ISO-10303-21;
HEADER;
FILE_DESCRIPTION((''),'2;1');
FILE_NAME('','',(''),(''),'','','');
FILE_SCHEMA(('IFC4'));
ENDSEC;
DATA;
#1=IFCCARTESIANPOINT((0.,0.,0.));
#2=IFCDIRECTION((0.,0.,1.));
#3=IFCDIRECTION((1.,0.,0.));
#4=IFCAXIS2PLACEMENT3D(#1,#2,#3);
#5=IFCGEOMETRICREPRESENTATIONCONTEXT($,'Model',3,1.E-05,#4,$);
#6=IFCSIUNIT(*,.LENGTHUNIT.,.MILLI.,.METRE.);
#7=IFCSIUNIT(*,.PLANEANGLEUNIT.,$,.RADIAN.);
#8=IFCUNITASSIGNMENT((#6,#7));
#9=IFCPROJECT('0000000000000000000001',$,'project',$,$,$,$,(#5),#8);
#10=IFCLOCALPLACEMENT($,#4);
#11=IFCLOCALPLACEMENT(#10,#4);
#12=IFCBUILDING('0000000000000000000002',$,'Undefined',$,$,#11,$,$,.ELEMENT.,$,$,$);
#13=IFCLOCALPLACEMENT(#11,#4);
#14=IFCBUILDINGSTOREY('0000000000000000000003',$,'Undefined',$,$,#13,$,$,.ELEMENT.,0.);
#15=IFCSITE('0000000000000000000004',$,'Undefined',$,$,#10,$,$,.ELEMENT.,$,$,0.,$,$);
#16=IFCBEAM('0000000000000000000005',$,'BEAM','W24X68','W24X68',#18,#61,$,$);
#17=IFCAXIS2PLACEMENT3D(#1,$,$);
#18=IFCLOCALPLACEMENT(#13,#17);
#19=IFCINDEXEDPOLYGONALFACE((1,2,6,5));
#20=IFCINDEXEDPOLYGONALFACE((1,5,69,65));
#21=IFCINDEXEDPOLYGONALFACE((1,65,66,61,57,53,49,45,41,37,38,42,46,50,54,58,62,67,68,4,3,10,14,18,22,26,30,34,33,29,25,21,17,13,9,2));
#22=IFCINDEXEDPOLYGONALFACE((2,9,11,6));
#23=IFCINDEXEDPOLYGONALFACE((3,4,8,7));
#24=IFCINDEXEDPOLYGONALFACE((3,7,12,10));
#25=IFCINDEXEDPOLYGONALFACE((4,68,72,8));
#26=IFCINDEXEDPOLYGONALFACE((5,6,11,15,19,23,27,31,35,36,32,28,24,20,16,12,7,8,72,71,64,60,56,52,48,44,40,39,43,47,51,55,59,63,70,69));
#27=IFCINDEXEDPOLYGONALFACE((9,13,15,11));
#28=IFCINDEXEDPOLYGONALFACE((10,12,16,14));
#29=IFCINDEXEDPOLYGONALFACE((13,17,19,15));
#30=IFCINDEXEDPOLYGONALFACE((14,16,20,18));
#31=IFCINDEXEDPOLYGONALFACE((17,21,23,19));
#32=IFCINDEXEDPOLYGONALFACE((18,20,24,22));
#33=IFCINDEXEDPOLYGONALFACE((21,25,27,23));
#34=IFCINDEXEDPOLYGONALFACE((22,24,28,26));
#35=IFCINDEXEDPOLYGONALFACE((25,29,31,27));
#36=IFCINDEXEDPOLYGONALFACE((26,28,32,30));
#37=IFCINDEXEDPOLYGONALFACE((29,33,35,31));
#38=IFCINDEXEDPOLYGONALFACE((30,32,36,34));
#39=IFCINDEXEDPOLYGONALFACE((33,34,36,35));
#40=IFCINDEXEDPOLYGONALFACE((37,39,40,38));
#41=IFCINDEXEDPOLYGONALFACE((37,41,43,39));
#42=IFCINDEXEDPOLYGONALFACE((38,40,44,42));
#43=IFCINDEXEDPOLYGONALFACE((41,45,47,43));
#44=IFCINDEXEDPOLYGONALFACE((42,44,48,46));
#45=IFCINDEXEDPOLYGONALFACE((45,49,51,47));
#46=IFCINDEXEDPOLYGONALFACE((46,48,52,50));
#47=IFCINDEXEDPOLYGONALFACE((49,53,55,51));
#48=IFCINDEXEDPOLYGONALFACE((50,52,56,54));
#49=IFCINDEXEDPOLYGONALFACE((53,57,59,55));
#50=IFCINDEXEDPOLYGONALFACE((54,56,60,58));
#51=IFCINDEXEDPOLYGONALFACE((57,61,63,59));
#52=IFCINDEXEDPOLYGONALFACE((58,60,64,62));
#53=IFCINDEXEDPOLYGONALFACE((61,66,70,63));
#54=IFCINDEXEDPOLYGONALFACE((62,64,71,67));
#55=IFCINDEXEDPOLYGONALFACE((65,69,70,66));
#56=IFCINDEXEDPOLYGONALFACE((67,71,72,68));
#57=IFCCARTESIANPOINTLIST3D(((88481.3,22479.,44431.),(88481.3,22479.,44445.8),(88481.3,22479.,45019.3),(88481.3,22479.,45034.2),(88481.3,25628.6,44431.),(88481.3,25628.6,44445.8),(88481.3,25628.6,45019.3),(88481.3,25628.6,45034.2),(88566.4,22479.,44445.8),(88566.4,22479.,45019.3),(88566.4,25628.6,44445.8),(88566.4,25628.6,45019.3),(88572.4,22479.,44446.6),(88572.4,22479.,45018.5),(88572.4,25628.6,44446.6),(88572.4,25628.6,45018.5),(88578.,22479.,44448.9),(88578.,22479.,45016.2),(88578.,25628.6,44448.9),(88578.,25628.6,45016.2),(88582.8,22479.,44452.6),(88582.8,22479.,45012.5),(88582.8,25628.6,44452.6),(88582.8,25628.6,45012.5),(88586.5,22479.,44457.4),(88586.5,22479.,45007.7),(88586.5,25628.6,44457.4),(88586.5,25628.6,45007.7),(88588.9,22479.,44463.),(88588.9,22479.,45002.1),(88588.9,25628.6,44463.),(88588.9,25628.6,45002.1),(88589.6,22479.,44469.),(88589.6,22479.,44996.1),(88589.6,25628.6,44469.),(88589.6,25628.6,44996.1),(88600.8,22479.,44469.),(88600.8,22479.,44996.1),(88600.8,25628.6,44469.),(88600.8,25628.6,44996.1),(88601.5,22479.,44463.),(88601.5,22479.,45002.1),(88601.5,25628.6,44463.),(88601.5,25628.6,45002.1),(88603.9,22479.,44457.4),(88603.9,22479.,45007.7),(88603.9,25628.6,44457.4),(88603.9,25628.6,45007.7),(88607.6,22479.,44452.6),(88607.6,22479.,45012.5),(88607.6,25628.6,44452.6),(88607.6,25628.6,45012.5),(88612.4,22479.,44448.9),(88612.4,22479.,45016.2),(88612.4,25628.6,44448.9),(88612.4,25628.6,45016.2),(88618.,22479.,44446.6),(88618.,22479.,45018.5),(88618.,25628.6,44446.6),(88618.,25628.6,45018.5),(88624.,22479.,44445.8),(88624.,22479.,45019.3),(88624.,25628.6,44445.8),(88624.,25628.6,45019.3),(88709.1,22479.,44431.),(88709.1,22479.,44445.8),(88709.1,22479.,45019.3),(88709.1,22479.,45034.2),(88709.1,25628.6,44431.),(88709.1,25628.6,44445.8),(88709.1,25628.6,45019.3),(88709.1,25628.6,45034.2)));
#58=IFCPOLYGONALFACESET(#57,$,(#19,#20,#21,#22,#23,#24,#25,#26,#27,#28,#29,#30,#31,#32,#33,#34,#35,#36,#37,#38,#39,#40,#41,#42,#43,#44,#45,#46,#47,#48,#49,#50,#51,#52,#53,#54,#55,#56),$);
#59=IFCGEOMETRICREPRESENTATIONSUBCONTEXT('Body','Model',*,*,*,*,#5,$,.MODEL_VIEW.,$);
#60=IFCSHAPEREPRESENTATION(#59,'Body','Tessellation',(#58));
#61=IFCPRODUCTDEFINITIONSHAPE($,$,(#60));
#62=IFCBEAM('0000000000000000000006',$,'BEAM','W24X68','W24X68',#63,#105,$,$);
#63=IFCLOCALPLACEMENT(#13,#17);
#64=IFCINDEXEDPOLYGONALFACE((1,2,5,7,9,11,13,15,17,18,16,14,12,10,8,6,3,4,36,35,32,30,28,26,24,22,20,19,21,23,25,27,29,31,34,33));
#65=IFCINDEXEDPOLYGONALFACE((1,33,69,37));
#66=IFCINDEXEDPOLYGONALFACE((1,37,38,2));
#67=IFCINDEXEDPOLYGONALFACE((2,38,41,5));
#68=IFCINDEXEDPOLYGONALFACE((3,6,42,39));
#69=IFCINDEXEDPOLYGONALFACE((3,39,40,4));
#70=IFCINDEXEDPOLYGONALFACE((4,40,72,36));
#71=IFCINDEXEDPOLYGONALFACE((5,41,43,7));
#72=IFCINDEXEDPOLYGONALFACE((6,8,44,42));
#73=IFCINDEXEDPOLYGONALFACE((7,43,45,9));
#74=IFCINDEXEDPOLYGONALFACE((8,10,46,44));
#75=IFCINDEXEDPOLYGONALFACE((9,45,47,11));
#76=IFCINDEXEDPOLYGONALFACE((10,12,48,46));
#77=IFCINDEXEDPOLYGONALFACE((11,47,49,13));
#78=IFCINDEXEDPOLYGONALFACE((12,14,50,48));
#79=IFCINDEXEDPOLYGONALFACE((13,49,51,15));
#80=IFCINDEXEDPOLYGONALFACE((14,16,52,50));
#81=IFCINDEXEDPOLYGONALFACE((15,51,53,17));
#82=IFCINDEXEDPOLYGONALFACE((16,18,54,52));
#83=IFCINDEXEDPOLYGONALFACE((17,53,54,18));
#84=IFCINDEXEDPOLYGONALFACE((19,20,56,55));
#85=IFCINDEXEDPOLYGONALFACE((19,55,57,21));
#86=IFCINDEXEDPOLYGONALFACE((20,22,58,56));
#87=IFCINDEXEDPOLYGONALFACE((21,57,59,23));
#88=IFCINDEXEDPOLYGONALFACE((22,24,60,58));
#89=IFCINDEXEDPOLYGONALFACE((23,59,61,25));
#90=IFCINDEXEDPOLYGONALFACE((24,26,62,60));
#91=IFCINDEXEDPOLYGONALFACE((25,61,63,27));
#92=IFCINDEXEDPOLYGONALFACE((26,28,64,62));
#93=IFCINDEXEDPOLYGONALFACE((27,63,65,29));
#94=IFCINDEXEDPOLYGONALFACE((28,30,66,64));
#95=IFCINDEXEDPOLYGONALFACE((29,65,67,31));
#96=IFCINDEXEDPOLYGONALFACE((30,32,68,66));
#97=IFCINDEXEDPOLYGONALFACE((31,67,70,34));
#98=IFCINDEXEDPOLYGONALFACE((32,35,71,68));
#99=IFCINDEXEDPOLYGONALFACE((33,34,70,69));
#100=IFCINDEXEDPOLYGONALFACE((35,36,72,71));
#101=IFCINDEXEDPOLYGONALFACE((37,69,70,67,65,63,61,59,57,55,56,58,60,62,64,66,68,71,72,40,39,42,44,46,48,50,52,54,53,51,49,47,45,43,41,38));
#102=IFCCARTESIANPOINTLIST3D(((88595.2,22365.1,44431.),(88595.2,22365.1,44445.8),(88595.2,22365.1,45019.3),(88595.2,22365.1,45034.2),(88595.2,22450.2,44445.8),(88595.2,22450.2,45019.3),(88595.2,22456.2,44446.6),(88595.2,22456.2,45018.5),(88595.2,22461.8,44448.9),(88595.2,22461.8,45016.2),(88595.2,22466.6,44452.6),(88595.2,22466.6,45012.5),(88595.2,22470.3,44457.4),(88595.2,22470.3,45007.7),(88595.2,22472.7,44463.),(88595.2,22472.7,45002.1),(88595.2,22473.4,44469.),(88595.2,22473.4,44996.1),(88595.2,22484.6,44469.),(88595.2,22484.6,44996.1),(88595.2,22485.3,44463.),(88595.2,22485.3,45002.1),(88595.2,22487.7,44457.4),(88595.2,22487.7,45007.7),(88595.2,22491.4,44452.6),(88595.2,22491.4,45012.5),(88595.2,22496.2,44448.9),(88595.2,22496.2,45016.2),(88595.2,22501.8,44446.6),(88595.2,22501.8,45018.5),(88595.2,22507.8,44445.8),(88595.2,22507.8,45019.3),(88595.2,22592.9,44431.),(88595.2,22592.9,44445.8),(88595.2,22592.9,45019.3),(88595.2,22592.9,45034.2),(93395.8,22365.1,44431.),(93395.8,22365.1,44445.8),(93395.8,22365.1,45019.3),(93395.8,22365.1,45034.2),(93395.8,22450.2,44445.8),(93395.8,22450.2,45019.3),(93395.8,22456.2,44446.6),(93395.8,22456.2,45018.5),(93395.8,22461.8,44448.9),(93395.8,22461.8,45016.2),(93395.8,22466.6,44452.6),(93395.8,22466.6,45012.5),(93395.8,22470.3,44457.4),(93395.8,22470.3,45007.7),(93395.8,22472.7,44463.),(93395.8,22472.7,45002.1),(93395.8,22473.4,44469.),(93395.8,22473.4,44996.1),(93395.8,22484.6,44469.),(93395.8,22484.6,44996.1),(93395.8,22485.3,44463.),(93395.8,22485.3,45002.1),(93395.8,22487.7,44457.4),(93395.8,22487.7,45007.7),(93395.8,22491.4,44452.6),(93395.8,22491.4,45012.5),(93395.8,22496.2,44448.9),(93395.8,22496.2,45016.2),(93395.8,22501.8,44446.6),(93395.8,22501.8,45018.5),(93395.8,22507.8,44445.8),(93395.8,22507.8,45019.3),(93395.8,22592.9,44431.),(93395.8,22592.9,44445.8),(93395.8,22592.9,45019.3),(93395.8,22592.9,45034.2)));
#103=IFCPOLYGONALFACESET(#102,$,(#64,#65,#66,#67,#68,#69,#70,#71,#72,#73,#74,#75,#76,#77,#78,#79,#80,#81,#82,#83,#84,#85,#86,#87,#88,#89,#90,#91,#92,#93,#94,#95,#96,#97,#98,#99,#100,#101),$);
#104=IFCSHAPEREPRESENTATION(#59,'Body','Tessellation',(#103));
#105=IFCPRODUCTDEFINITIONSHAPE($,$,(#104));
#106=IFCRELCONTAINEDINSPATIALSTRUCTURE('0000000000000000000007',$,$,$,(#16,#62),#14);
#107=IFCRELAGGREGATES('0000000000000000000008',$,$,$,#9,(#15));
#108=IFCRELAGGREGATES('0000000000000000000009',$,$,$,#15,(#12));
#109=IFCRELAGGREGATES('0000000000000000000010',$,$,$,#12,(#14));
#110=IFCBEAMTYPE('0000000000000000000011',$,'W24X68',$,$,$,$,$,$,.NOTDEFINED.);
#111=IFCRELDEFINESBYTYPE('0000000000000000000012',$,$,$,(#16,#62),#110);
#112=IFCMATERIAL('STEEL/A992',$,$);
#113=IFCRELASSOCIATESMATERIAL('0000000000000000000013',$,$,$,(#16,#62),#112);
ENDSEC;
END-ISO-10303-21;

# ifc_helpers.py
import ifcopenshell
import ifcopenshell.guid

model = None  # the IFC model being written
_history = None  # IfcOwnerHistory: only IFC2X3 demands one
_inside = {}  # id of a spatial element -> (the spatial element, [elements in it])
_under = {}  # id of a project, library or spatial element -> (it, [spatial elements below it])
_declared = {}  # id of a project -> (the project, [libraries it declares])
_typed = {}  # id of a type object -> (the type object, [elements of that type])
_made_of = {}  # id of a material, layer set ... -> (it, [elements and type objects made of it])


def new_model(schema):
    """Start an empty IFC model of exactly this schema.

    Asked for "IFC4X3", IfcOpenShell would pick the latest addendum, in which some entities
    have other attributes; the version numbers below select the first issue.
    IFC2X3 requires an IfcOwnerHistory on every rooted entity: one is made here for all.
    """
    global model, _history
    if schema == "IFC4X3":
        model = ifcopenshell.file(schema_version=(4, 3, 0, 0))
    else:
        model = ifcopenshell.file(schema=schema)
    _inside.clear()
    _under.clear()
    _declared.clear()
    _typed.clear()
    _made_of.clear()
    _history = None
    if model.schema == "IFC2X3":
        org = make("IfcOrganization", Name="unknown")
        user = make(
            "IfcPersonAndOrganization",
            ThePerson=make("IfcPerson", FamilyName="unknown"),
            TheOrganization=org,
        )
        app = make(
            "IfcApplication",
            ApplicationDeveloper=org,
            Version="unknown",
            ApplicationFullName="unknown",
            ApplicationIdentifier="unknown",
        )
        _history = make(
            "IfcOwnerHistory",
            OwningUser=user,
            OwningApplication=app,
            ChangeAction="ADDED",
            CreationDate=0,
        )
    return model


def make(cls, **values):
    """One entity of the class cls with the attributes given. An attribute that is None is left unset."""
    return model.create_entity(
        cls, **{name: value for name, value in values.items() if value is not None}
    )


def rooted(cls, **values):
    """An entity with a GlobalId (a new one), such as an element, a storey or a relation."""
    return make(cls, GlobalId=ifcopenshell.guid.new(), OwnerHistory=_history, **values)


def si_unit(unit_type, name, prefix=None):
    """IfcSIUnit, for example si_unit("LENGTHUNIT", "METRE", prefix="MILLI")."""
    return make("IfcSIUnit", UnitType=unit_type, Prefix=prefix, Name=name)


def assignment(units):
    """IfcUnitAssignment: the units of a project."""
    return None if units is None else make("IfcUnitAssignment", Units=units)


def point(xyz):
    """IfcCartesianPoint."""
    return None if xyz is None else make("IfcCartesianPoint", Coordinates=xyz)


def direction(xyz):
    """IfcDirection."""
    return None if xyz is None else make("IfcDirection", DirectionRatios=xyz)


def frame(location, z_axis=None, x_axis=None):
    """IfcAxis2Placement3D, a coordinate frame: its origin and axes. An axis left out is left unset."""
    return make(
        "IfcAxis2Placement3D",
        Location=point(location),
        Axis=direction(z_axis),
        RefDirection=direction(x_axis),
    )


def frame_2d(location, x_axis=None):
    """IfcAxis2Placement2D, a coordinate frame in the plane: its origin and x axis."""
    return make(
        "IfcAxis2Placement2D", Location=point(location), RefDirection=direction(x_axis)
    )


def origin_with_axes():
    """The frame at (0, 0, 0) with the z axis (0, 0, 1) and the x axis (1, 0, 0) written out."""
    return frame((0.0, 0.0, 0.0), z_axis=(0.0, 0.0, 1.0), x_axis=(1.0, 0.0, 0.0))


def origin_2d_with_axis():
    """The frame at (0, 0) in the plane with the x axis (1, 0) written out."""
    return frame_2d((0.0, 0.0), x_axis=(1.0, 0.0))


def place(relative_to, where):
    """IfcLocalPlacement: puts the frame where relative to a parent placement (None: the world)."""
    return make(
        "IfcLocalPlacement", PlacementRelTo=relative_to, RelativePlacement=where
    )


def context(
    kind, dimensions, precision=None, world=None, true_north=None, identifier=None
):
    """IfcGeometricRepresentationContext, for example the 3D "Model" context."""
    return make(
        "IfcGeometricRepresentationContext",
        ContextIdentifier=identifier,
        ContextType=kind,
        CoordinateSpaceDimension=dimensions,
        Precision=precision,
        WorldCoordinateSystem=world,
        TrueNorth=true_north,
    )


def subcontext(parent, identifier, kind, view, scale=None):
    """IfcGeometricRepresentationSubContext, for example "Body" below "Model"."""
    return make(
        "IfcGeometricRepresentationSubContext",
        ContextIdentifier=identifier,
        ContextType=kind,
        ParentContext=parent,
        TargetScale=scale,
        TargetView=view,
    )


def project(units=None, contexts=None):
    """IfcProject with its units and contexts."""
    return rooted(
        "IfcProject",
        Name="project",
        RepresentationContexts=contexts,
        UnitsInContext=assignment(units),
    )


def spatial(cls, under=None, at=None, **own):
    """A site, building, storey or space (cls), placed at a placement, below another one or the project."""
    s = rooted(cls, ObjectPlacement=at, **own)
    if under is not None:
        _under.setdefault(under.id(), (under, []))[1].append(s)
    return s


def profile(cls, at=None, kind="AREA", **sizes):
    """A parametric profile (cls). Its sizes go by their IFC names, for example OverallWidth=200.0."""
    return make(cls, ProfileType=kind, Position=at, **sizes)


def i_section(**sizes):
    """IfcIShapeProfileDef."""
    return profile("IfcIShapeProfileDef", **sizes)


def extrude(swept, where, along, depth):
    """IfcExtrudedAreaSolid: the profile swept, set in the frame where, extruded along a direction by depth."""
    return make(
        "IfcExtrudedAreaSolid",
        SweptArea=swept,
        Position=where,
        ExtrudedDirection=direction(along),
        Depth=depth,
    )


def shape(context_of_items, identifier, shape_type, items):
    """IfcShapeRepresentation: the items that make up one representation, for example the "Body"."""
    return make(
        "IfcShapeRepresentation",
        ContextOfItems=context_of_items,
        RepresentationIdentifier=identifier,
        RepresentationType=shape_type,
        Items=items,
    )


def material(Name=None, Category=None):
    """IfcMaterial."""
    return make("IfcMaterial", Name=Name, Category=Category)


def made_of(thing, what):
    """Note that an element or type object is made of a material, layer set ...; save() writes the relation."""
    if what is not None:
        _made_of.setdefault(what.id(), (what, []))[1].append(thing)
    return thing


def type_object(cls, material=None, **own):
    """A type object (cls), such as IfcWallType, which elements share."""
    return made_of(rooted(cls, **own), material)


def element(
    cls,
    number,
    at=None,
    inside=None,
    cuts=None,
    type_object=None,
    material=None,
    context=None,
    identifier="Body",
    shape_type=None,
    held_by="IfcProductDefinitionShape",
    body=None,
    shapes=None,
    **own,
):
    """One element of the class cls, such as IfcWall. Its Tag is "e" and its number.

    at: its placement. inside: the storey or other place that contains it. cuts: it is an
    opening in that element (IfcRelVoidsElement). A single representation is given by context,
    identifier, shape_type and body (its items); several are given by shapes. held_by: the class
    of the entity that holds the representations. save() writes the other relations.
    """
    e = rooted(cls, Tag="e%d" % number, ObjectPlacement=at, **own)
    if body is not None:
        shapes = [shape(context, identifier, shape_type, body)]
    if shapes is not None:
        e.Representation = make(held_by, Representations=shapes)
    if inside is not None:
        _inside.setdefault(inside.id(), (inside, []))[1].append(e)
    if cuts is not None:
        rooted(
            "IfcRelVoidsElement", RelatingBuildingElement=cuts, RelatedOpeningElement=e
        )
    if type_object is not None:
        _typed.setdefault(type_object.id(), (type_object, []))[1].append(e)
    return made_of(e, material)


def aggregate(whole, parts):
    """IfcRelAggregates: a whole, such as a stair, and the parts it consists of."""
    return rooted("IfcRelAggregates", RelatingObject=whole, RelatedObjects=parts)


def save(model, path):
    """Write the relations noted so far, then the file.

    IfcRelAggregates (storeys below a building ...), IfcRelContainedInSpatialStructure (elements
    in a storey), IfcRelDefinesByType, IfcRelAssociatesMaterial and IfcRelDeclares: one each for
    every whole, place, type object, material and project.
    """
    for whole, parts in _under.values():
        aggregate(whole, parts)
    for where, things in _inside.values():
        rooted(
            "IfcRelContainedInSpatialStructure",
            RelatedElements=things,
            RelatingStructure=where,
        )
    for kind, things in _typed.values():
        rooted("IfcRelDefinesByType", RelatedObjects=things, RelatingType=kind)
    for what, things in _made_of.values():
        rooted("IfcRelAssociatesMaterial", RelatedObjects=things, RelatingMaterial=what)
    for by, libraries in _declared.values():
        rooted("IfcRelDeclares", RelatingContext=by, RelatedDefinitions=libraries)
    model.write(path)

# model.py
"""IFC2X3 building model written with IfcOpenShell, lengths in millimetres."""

from ifc_helpers import new_model, si_unit, frame, origin_with_axes, origin_2d_with_axis, place, context, subcontext, project, spatial, i_section, extrude, material, type_object, element, save


model = new_model("IFC2X3")

# Units and contexts
model_context = context("Model", 3, precision=1e-05, world=origin_with_axes())
body_context = subcontext(model_context, "Body", "Model", "MODEL_VIEW")
ifc_project = project(units=[si_unit("LENGTHUNIT", "METRE", prefix="MILLI"), si_unit("PLANEANGLEUNIT", "RADIAN")], contexts=[model_context])

# Site, building, storey
site_placement = place(None, origin_with_axes())
site = spatial("IfcSite", under=ifc_project, at=site_placement, Name="Undefined", CompositionType="ELEMENT", RefElevation=0.0)
building_placement = place(site_placement, origin_with_axes())
building = spatial("IfcBuilding", under=site, at=building_placement, Name="Undefined", CompositionType="ELEMENT")
storey_placement = place(building_placement, origin_with_axes())
storey = spatial("IfcBuildingStorey", under=building, at=storey_placement, Name="Undefined", CompositionType="ELEMENT", Elevation=0.0)

# Shared definitions
ifc_material = material(Name="STEEL/A992")

# Beams
beam_type = type_object("IfcBeamType", Name="W24X68", PredefinedType="NOTDEFINED")
beam_1_placement = place(storey_placement, frame((88595.2, 22479.0, 44732.6), z_axis=(0.0, 0.0, 1.0), x_axis=(0.0, 1.0, 0.0)))
element("IfcBeam", 1, at=beam_1_placement, inside=storey, type_object=beam_type, material=ifc_material, Name="BEAM", Description="W24X68", ObjectType="W24X68", context=body_context, shape_type="SweptSolid", body=[
    extrude(i_section(OverallWidth=227.8, OverallDepth=603.2, WebThickness=11.1, FlangeThickness=14.9, FilletRadius=23.2, at=origin_2d_with_axis()), frame((3149.6, 0.0, 0.0), z_axis=(-1.0, 0.0, 0.0), x_axis=(0.0, -1.0, 0.0)), (0.0, 0.0, 1.0), 3149.6),
])
beam_2_placement = place(storey_placement, frame((88595.2, 22479.0, 44732.6), z_axis=(0.0, 0.0, 1.0), x_axis=(1.0, 0.0, 0.0)))
element("IfcBeam", 2, at=beam_2_placement, inside=storey, type_object=beam_type, material=ifc_material, Name="BEAM", Description="W24X68", ObjectType="W24X68", context=body_context, shape_type="SweptSolid", body=[
    extrude(i_section(OverallWidth=227.8, OverallDepth=603.2, WebThickness=11.1, FlangeThickness=14.9, FilletRadius=23.2, at=origin_2d_with_axis()), frame((4800.6, 0.0, 0.0), z_axis=(-1.0, 0.0, 0.0), x_axis=(0.0, -1.0, 0.0)), (0.0, 0.0, 1.0), 4800.6),
])

save(model, "model.ifc")
